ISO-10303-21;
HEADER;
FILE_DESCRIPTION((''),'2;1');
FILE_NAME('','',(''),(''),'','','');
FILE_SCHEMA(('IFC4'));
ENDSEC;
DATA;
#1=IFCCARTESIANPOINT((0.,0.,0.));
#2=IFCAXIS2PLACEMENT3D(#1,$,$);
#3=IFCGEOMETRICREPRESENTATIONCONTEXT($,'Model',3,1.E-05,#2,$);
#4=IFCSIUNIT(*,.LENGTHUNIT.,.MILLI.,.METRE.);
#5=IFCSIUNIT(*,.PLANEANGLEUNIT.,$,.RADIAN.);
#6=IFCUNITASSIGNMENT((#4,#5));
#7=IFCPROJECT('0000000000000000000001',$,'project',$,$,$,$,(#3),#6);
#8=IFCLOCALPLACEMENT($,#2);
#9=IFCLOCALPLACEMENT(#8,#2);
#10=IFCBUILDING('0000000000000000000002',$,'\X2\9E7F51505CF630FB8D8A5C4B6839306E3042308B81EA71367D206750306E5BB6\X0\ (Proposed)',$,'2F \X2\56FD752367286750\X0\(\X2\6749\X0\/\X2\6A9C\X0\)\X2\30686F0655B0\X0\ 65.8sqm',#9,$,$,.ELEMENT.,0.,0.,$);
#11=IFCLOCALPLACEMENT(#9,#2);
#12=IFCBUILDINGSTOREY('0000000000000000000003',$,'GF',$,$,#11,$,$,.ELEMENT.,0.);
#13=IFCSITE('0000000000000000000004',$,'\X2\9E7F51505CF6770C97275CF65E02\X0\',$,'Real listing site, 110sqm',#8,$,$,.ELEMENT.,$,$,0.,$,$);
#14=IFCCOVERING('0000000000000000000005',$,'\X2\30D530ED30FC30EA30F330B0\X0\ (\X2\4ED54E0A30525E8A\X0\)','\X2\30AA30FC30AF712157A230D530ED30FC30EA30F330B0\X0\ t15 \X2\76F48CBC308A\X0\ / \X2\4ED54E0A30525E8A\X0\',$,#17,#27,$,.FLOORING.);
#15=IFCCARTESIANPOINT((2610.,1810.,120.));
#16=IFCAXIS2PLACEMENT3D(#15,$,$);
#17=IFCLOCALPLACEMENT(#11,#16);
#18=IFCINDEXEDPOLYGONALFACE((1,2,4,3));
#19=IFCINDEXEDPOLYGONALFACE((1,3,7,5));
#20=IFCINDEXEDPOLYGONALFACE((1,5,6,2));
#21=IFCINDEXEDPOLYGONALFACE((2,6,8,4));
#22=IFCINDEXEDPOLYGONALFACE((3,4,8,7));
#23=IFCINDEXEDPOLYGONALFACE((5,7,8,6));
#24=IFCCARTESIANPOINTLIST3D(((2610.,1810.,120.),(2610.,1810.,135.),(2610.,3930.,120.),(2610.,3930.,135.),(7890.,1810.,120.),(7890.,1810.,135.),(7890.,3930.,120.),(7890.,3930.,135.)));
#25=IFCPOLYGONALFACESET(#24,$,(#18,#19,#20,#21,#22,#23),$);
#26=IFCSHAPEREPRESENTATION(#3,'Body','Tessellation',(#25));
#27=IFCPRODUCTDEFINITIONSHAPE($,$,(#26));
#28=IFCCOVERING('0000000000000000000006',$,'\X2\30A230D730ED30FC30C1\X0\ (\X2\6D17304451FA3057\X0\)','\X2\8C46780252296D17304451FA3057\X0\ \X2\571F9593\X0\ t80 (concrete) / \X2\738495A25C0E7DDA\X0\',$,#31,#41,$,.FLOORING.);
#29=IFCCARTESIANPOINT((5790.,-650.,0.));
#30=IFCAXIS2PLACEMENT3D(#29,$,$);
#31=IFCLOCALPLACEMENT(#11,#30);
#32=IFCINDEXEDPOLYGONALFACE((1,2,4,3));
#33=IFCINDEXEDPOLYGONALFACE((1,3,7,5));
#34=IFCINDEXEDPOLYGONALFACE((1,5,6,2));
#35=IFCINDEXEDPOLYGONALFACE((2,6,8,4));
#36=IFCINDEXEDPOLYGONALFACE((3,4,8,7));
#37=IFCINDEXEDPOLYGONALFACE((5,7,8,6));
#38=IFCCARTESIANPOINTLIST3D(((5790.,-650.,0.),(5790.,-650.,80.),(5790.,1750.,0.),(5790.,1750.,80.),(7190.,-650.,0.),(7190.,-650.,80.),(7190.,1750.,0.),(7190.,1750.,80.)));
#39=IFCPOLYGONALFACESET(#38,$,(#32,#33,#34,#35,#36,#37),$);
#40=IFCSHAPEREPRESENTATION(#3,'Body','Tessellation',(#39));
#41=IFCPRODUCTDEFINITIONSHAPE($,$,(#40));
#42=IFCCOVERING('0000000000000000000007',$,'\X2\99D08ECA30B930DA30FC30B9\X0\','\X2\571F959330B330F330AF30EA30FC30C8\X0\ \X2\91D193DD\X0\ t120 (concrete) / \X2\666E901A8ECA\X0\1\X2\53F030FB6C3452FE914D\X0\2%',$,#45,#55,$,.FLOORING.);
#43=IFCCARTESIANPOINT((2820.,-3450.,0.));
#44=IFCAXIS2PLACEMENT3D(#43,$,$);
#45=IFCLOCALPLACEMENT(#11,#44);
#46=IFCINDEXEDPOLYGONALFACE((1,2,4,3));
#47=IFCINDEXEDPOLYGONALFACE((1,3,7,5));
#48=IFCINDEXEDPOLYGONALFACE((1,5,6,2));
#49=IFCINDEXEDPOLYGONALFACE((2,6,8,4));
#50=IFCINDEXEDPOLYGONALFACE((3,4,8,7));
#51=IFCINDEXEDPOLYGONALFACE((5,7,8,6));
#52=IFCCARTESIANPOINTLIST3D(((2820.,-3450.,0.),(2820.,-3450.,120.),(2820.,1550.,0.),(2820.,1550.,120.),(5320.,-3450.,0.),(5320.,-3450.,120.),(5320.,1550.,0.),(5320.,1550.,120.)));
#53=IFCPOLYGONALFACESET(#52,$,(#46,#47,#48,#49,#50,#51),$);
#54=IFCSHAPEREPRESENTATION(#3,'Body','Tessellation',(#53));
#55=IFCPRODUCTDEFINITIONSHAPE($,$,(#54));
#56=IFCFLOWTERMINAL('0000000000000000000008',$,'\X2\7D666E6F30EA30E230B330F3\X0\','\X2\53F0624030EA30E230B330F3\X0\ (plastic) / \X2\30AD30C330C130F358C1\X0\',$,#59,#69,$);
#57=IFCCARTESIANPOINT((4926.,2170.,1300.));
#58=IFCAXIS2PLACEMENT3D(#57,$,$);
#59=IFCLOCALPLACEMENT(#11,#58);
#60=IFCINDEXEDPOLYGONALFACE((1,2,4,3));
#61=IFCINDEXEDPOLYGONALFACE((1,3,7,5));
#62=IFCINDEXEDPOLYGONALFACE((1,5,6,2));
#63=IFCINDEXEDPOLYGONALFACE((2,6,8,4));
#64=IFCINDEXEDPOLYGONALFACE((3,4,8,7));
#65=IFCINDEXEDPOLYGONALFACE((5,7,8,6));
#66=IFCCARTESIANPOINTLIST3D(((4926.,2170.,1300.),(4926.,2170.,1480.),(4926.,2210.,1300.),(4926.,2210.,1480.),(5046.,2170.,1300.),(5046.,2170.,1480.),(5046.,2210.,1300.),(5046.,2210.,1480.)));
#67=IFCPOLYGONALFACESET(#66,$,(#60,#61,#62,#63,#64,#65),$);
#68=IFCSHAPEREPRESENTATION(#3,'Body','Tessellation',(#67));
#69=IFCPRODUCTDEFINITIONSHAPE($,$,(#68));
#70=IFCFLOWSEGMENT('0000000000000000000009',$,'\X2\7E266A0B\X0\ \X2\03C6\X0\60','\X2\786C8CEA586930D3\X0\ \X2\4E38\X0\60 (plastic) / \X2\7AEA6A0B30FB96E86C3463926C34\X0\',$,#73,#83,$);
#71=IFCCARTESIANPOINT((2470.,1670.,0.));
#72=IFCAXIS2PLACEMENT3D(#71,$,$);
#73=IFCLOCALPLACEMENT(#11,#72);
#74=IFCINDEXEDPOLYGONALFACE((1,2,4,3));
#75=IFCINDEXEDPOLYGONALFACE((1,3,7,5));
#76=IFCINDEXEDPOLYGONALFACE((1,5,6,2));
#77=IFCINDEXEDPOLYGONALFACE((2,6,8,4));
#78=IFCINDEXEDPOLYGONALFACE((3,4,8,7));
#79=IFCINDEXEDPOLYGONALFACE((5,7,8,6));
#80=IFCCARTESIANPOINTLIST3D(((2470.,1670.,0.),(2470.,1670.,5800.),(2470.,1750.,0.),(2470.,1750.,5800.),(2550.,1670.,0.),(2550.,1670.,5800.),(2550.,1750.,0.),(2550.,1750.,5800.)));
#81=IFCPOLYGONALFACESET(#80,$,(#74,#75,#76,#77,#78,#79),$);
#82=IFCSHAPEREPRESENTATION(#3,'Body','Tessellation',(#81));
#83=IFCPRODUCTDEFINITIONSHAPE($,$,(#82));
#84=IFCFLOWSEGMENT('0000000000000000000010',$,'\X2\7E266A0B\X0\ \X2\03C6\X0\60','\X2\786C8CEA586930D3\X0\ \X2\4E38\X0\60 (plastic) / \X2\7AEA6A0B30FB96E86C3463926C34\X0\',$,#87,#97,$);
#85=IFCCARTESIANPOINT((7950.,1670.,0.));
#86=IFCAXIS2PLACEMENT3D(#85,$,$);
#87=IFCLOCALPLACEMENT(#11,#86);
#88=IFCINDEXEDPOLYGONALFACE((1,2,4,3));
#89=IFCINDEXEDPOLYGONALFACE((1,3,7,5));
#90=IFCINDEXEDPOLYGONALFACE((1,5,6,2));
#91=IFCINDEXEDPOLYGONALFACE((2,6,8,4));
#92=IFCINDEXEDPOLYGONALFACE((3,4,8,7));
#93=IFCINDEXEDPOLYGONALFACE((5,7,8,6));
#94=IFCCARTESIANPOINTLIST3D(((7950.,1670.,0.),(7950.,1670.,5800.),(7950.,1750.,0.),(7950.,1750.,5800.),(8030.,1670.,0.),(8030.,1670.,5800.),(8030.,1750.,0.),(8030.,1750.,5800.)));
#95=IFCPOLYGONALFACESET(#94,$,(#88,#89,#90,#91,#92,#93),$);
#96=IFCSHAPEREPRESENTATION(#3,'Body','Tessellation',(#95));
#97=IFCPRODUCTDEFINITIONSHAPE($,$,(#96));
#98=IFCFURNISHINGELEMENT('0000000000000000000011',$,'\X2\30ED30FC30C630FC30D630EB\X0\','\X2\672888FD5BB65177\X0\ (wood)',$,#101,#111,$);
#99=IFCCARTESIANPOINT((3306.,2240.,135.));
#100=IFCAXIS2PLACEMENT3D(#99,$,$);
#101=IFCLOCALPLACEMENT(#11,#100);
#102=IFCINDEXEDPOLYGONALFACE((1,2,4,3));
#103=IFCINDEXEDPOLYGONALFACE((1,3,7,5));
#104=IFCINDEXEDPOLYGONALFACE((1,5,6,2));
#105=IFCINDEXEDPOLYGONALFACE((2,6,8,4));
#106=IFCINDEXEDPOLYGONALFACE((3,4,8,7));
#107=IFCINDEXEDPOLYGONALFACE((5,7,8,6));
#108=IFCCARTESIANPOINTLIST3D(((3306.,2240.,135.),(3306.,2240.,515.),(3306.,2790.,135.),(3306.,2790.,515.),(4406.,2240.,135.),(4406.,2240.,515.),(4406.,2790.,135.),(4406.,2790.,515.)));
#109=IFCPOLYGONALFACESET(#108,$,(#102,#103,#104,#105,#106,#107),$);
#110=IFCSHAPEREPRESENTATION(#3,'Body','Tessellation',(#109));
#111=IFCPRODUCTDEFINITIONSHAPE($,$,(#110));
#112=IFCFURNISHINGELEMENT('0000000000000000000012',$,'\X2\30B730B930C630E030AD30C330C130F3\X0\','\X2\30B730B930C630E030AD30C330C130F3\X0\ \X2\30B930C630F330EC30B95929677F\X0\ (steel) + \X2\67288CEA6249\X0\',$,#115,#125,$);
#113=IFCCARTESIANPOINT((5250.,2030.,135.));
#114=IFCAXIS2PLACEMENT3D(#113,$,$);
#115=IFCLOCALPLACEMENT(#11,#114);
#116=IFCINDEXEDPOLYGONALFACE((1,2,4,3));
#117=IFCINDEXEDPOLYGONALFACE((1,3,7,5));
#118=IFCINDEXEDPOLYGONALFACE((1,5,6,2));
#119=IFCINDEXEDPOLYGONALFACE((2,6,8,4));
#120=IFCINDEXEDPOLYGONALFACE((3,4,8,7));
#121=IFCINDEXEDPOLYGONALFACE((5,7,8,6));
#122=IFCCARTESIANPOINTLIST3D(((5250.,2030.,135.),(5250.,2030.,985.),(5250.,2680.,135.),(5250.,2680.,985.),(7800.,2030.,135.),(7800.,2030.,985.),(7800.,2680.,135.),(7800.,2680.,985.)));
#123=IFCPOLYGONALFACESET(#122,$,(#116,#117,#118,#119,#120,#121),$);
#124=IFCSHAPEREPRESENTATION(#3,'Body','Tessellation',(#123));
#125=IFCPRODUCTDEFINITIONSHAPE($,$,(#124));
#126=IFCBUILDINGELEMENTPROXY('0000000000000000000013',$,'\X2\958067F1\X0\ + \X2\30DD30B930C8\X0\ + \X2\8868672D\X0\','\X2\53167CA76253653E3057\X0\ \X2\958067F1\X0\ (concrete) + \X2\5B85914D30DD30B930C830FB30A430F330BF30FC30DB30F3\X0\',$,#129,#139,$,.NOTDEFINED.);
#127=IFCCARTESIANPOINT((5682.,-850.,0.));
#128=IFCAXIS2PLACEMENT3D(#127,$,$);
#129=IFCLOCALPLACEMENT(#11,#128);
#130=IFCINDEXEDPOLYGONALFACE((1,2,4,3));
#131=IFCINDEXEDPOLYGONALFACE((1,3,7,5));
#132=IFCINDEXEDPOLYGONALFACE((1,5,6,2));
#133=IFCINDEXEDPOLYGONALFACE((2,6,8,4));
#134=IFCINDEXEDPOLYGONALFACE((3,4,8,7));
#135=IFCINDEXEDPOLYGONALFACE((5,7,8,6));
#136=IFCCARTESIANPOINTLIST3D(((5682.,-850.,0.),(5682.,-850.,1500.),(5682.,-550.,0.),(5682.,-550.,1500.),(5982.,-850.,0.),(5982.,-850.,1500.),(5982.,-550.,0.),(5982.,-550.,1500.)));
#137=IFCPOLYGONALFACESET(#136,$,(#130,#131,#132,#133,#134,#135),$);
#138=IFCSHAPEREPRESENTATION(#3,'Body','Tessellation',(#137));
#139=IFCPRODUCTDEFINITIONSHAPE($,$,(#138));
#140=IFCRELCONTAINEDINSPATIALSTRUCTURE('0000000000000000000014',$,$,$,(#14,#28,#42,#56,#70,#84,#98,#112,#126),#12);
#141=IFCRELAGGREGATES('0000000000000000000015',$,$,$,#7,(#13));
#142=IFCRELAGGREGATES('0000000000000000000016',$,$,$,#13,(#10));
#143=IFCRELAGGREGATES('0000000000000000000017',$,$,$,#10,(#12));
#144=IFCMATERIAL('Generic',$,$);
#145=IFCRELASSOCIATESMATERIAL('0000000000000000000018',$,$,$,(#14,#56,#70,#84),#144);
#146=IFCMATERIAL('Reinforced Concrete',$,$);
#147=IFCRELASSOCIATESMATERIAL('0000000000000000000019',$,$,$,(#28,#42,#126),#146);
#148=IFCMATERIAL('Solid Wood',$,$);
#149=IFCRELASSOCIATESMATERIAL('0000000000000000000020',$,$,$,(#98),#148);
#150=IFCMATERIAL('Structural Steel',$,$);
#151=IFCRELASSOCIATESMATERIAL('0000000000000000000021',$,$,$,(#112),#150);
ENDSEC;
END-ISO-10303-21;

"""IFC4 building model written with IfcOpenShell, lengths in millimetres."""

from ifc_helpers import new_model, si_unit, frame, frame_2d, origin, place, context, project, spatial, rectangle, extrude, material, element, save


model = new_model("IFC4")

# Units and contexts
model_context = context("Model", 3, precision=1e-05, world=origin())
ifc_project = project(units=[si_unit("LENGTHUNIT", "METRE", prefix="MILLI"), si_unit("PLANEANGLEUNIT", "RADIAN")], contexts=[model_context])

# Site, building, storey
site_placement = place(None, origin())
site = spatial("IfcSite", under=ifc_project, at=site_placement, Name="鹿児島県霧島市", ObjectType="Real listing site, 110sqm", CompositionType="ELEMENT", RefElevation=0.0)
building_placement = place(site_placement, origin())
building = spatial("IfcBuilding", under=site, at=building_placement, Name="鹿児島・越屋根のある自然素材の家 (Proposed)", ObjectType="2F 国産木材(杉/檜)と漆喰 65.8sqm", CompositionType="ELEMENT", ElevationOfRefHeight=0.0, ElevationOfTerrain=0.0)
storey_placement = place(building_placement, origin())
storey = spatial("IfcBuildingStorey", under=building, at=storey_placement, Name="GF", CompositionType="ELEMENT", Elevation=0.0)

# Shared definitions
ifc_material_1 = material(Name="Solid Wood")

# Shared definitions
ifc_material_2 = material(Name="Reinforced Concrete")

# Coverings
ifc_material_3 = material(Name="Generic")
covering_1_placement = place(storey_placement, frame((2610.0, 1810.0, 120.0)))
element("IfcCovering", 1, at=covering_1_placement, inside=storey, material=ifc_material_3, Name="フローリング (仕上げ床)", Description="オーク無垢フローリング t15 直貼り / 仕上げ床", PredefinedType="FLOORING", context=model_context, shape_type="SweptSolid", body=[
    extrude(rectangle(XDim=5280.0, YDim=2120.0, at=frame_2d((2640.0, 1060.0))), frame((2610.0, 1810.0, 120.0)), (0.0, 0.0, 1.0), 15.0),
])
covering_2_placement = place(storey_placement, frame((5790.0, -650.0, 0.0)))
element("IfcCovering", 2, at=covering_2_placement, inside=storey, material=ifc_material_2, Name="アプローチ (洗い出し)", Description="豆砂利洗い出し 土間 t80 (concrete) / 玄関導線", PredefinedType="FLOORING", context=model_context, shape_type="SweptSolid", body=[
    extrude(rectangle(XDim=1400.0, YDim=2400.0, at=frame_2d((700.0, 1200.0))), frame((5790.0, -650.0, 0.0)), (0.0, 0.0, 1.0), 80.0),
])
covering_3_placement = place(storey_placement, frame((2820.0, -3450.0, 0.0)))
element("IfcCovering", 3, at=covering_3_placement, inside=storey, material=ifc_material_2, Name="駐車スペース", Description="土間コンクリート 金鏝 t120 (concrete) / 普通車1台・水勾配2%", PredefinedType="FLOORING", context=model_context, shape_type="SweptSolid", body=[
    extrude(rectangle(XDim=2500.0, YDim=5000.0, at=frame_2d((1250.0, 2500.0))), frame((2820.0, -3450.0, 0.0)), (0.0, 0.0, 1.0), 120.0),
])

# Flow terminal
flow_terminal_placement = place(storey_placement, frame((4926.0, 2170.0, 1300.0)))
element("IfcFlowTerminal", 4, at=flow_terminal_placement, inside=storey, material=ifc_material_3, Name="給湯リモコン", Description="台所リモコン (plastic) / キッチン壁", context=model_context, shape_type="SweptSolid", body=[
    extrude(rectangle(XDim=120.0, YDim=40.0, at=frame_2d((60.0, 20.0))), frame((4926.0, 2170.0, 1300.0)), (0.0, 0.0, 1.0), 180.0),
])

# Flow segments
flow_segment_1_placement = place(storey_placement, frame((2470.0, 1670.0, 0.0)))
element("IfcFlowSegment", 5, at=flow_segment_1_placement, inside=storey, material=ifc_material_3, Name="縦樋 φ60", Description="硬質塩ビ 丸60 (plastic) / 竪樋・雨水排水", context=model_context, shape_type="SweptSolid", body=[
    extrude(rectangle(XDim=80.0, YDim=80.0, at=frame_2d((40.0, 40.0))), frame((2470.0, 1670.0, 0.0)), (0.0, 0.0, 1.0), 5800.0),
])
flow_segment_2_placement = place(storey_placement, frame((7950.0, 1670.0, 0.0)))
element("IfcFlowSegment", 6, at=flow_segment_2_placement, inside=storey, material=ifc_material_3, Name="縦樋 φ60", Description="硬質塩ビ 丸60 (plastic) / 竪樋・雨水排水", context=model_context, shape_type="SweptSolid", body=[
    extrude(rectangle(XDim=80.0, YDim=80.0, at=frame_2d((40.0, 40.0))), frame((7950.0, 1670.0, 0.0)), (0.0, 0.0, 1.0), 5800.0),
])

# Furnishing elements
furnishing_1_placement = place(storey_placement, frame((3306.0, 2240.0, 135.0)))
element("IfcFurnishingElement", 7, at=furnishing_1_placement, inside=storey, material=ifc_material_1, Name="ローテーブル", Description="木製家具 (wood)", context=model_context, shape_type="SweptSolid", body=[
    extrude(rectangle(XDim=1100.0, YDim=550.0, at=frame_2d((550.0, 275.0))), frame((3306.0, 2240.0, 135.0)), (0.0, 0.0, 1.0), 380.0),
])
ifc_material_4 = material(Name="Structural Steel")
furnishing_2_placement = place(storey_placement, frame((5250.0, 2030.0, 135.0)))
element("IfcFurnishingElement", 8, at=furnishing_2_placement, inside=storey, material=ifc_material_4, Name="システムキッチン", Description="システムキッチン ステンレス天板 (steel) + 木質扉", context=model_context, shape_type="SweptSolid", body=[
    extrude(rectangle(XDim=2550.0, YDim=650.0, at=frame_2d((1275.0, 325.0))), frame((5250.0, 2030.0, 135.0)), (0.0, 0.0, 1.0), 850.0),
])

# Building element proxy
proxy_placement = place(storey_placement, frame((5682.0, -850.0, 0.0)))
element("IfcBuildingElementProxy", 9, at=proxy_placement, inside=storey, material=ifc_material_2, Name="門柱 + ポスト + 表札", Description="化粧打放し 門柱 (concrete) + 宅配ポスト・インターホン", PredefinedType="NOTDEFINED", context=model_context, shape_type="SweptSolid", body=[
    extrude(rectangle(XDim=300.0, YDim=300.0, at=frame_2d((150.0, 150.0))), frame((5682.0, -850.0, 0.0)), (0.0, 0.0, 1.0), 1500.0),
])

save(model, "model.ifc")
